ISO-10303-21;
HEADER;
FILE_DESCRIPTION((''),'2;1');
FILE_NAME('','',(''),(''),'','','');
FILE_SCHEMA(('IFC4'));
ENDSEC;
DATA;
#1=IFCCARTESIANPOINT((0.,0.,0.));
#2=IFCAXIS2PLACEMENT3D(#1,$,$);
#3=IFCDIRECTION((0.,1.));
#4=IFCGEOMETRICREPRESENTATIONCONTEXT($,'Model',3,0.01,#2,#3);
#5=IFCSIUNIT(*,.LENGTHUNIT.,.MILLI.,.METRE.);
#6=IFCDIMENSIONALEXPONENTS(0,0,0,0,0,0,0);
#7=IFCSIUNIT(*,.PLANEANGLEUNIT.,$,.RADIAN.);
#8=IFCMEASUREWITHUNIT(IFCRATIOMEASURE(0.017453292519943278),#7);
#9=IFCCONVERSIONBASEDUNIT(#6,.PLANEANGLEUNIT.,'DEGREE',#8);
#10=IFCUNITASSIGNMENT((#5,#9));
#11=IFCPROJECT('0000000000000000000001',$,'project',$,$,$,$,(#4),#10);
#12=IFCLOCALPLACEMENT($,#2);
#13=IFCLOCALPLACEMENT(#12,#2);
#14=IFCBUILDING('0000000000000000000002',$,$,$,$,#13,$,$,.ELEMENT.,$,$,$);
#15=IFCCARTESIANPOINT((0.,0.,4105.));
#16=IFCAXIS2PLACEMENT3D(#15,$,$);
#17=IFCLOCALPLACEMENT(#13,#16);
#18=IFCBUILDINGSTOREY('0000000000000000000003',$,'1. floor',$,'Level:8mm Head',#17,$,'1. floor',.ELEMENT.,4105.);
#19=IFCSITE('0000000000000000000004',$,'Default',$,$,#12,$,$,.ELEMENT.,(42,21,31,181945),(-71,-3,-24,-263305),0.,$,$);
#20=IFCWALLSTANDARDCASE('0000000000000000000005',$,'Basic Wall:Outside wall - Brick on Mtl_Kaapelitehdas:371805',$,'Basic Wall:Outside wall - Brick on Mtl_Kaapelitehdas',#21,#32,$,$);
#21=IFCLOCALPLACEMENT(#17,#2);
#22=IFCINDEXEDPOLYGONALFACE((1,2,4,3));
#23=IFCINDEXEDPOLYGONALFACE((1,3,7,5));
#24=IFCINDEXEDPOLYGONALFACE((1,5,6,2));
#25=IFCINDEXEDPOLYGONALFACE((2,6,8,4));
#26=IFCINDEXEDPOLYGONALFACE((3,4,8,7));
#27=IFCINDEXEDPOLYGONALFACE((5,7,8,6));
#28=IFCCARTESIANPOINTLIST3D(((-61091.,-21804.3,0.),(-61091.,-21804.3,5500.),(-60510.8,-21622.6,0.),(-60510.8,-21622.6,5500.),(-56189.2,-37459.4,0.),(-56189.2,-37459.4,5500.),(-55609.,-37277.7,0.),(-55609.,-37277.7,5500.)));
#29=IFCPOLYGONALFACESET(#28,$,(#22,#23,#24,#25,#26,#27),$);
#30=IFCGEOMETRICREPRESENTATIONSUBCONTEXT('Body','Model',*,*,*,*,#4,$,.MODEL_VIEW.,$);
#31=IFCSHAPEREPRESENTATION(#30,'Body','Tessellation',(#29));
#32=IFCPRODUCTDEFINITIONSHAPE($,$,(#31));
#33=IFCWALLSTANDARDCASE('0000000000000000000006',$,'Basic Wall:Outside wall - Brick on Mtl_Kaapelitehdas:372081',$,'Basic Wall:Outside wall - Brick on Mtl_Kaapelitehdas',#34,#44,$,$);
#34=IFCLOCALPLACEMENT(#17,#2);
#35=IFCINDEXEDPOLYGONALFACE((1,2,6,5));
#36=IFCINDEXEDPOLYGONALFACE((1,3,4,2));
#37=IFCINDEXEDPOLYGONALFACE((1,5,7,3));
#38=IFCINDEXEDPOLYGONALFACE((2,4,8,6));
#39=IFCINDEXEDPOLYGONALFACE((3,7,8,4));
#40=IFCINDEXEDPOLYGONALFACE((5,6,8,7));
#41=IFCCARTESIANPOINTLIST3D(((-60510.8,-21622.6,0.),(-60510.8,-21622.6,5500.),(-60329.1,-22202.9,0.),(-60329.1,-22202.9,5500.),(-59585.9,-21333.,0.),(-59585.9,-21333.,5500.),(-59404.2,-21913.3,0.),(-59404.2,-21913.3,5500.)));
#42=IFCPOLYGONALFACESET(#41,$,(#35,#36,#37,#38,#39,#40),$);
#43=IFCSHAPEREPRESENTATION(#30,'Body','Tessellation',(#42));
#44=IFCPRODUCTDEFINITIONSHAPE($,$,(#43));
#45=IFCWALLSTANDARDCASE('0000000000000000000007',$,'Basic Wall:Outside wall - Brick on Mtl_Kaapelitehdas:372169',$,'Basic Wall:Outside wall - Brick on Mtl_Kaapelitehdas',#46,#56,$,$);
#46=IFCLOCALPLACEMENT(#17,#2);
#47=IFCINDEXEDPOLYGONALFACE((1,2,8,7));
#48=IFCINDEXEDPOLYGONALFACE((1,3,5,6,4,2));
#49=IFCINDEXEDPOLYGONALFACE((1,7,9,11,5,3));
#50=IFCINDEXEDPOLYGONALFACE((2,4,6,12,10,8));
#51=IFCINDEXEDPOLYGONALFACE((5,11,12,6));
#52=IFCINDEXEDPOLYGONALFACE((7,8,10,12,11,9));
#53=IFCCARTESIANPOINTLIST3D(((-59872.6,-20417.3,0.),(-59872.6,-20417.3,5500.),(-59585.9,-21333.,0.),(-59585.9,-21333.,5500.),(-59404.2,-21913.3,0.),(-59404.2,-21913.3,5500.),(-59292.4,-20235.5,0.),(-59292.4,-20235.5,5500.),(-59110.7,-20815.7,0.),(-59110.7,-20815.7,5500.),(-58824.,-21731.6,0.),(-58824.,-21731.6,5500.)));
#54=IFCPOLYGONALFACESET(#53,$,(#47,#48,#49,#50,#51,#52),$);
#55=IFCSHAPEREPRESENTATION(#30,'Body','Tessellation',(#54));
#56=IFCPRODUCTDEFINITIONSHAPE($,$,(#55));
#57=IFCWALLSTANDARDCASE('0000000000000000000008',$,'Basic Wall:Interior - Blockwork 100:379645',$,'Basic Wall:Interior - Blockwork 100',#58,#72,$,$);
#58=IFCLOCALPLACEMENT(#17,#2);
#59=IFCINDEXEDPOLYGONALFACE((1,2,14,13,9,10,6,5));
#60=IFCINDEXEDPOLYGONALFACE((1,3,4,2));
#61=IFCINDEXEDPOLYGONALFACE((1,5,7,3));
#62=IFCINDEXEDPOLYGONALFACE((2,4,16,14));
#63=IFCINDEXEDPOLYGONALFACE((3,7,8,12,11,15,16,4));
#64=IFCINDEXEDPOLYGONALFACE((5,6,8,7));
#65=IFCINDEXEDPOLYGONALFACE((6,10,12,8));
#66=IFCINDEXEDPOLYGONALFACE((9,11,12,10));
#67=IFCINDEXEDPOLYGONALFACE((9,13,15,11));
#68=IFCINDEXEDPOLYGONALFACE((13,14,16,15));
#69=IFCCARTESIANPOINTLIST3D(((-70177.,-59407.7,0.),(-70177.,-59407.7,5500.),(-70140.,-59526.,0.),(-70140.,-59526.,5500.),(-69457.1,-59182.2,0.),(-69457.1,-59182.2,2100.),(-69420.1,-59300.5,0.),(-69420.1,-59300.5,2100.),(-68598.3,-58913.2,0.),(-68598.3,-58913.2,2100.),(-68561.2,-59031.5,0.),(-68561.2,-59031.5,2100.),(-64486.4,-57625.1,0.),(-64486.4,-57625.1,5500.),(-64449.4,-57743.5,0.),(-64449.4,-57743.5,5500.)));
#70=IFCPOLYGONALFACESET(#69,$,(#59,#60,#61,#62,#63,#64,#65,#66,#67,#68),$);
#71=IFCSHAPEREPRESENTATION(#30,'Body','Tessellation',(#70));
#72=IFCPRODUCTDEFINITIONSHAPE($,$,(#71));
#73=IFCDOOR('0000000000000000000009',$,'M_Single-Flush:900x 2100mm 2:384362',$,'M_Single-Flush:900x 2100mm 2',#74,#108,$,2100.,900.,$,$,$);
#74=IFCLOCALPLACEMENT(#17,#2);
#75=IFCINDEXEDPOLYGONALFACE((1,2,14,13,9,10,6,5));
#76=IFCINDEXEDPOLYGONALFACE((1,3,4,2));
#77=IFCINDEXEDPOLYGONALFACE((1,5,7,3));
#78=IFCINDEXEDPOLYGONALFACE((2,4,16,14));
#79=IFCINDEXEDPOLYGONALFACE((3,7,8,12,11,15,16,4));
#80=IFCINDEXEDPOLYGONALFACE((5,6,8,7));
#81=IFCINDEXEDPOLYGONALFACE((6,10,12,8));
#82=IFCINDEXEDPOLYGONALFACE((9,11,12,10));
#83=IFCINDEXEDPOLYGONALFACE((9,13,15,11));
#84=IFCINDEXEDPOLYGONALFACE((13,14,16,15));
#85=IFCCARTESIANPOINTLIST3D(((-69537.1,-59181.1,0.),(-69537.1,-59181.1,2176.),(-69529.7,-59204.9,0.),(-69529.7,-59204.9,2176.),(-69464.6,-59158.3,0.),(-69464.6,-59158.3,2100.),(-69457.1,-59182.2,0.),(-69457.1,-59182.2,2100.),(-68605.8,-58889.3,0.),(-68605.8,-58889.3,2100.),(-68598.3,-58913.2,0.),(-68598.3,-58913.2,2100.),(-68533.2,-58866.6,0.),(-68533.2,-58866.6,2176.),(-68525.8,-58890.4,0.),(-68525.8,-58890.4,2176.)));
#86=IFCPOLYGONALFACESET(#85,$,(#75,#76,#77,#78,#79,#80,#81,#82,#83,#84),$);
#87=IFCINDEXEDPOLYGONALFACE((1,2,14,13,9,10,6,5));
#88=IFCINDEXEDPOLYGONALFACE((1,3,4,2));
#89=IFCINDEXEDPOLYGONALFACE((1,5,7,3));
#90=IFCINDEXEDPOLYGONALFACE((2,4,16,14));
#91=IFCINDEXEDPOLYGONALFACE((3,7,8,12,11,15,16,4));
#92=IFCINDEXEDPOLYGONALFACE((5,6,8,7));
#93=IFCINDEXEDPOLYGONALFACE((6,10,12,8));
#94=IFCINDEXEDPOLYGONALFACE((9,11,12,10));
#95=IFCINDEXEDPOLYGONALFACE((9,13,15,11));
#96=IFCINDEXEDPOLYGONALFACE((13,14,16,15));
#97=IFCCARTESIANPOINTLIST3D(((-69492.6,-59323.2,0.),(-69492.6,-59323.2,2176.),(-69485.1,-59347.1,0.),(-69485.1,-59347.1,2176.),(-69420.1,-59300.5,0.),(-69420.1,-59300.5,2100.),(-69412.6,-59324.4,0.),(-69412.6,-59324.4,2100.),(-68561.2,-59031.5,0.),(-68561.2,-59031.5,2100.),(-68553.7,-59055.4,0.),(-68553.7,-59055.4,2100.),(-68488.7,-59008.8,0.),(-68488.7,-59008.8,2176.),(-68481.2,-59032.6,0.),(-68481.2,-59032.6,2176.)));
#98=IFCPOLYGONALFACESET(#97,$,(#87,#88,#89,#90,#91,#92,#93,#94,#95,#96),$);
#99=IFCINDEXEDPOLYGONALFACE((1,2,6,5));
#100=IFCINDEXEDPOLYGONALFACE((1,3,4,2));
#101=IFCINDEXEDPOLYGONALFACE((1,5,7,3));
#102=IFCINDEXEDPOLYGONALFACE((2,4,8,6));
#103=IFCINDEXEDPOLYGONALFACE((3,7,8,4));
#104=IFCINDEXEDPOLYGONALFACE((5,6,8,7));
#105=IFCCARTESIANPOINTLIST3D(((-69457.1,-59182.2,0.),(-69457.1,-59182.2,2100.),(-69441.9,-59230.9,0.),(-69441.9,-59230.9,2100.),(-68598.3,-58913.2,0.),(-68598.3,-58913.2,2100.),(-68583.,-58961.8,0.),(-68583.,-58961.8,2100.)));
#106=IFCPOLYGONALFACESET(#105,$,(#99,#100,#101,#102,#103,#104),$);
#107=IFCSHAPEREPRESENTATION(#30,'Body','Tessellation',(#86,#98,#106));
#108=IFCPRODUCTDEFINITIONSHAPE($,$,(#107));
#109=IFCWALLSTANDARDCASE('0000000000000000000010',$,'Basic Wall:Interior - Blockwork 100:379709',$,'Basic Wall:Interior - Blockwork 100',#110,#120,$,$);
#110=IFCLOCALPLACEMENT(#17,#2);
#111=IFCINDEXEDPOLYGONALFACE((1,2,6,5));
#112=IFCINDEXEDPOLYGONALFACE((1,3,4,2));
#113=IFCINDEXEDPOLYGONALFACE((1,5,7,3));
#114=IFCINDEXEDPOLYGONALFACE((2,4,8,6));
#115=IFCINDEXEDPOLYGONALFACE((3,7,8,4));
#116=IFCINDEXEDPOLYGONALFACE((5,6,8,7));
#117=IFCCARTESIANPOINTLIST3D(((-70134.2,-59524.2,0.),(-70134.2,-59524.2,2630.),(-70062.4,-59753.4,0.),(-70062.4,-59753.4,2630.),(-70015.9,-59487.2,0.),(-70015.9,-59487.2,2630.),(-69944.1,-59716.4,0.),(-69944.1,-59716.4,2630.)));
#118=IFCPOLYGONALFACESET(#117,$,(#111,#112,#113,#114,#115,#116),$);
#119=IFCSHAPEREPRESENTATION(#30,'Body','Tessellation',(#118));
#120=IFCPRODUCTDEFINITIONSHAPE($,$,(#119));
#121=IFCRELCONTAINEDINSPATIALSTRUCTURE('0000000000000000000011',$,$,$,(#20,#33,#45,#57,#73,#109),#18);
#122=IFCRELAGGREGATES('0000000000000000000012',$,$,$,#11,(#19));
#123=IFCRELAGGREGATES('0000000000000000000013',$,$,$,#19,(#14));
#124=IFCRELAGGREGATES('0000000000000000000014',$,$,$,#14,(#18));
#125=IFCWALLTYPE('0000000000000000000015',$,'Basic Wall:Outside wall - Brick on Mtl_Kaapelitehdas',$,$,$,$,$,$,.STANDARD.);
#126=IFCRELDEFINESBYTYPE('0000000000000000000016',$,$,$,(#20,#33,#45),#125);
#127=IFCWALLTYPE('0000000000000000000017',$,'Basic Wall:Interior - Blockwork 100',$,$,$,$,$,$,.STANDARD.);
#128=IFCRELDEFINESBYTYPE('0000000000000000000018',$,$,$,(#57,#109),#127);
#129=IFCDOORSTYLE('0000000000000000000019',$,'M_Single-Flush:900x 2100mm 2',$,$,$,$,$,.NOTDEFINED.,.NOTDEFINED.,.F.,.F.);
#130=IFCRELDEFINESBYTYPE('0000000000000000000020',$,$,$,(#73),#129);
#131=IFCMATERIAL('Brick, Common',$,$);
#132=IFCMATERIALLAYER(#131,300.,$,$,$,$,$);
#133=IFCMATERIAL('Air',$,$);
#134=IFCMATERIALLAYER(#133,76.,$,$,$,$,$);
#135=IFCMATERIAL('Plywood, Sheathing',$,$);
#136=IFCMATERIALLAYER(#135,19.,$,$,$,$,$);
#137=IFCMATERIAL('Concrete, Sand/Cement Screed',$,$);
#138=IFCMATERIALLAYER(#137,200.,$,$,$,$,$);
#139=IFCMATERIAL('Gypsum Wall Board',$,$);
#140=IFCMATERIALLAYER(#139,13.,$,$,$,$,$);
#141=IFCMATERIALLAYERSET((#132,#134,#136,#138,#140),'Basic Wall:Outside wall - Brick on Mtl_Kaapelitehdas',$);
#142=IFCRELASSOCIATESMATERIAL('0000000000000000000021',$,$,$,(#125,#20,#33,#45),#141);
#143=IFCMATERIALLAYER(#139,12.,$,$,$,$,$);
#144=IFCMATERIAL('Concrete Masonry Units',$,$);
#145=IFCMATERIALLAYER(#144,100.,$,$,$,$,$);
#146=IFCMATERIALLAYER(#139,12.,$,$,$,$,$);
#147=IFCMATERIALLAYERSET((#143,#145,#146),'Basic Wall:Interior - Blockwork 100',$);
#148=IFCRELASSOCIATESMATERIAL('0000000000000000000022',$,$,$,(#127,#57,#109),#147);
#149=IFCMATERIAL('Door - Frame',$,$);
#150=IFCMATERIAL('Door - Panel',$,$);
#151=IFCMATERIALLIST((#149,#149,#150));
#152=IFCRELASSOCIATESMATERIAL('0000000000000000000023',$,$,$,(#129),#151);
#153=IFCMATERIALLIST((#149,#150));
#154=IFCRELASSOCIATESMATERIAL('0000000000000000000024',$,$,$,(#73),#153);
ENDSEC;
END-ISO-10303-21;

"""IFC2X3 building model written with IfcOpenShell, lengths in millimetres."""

from ifc_helpers import new_model, entity, si_unit, converted_unit, direction, frame, frame_2d, origin, origin_2d_with_axis, place, context, subcontext, project, spatial, polyline, rectangle, outline, extrude, source, transform, mapped, material, material_list, layer, layer_set, layer_usage, type_object, type_shapes, element, fill, save


model = new_model("IFC2X3")

# Units and contexts
model_context = context("Model", 3, precision=0.01, world=origin(), true_north=direction((0.0, 1.0)))
body_context = subcontext(model_context, "Body", "Model", "MODEL_VIEW")
ifc_project = project(units=[si_unit("LENGTHUNIT", "METRE", prefix="MILLI"), converted_unit("PLANEANGLEUNIT", "DEGREE", entity("IfcRatioMeasure", 0.017453292519943278), si_unit("PLANEANGLEUNIT", "RADIAN"), dimensions=[0, 0, 0, 0, 0, 0, 0])], contexts=[model_context])

# Site, building, storey
site_placement = place(None, origin())
site = spatial("IfcSite", under=ifc_project, at=site_placement, Name="Default", CompositionType="ELEMENT", RefLatitude=(42, 21, 31, 181945), RefLongitude=(-71, -3, -24, -263305), RefElevation=0.0)
building_placement = place(site_placement, origin())
building = spatial("IfcBuilding", under=site, at=building_placement, CompositionType="ELEMENT")
storey_placement = place(building_placement, frame((0.0, 0.0, 4105.0)))
storey = spatial("IfcBuildingStorey", under=building, at=storey_placement, Name="1. floor", ObjectType="Level:8mm Head", LongName="1. floor", CompositionType="ELEMENT", Elevation=4105.0)

# Walls
ifc_material_1 = material(Name="Brick, Common")
ifc_layer_1 = layer(ifc_material_1, 300.0)
ifc_material_2 = material(Name="Air")
ifc_layer_2 = layer(ifc_material_2, 76.0)
ifc_material_3 = material(Name="Plywood, Sheathing")
ifc_layer_3 = layer(ifc_material_3, 19.0)
ifc_material_4 = material(Name="Concrete, Sand/Cement Screed")
ifc_layer_4 = layer(ifc_material_4, 200.0)
ifc_material_5 = material(Name="Gypsum Wall Board")
ifc_layer_5 = layer(ifc_material_5, 13.0)
ifc_layer_set_1 = layer_set([ifc_layer_1, ifc_layer_2, ifc_layer_3, ifc_layer_4, ifc_layer_5], Name="Basic Wall:Outside wall - Brick on Mtl_Kaapelitehdas")
ifc_layer_usage_1 = layer_usage(ifc_layer_set_1, "AXIS2", "NEGATIVE", 304.0)
wall_type_1 = type_object("IfcWallType", Name="Basic Wall:Outside wall - Brick on Mtl_Kaapelitehdas", PredefinedType="STANDARD", material=ifc_layer_set_1)
wall_1_placement = place(storey_placement, frame((-60800.9, -21713.5, 0.0), z_axis=(0.0, 0.0, 1.0), x_axis=(0.298805, -0.954314, 0.0)))
element("IfcWallStandardCase", 1, at=wall_1_placement, inside=storey, type_object=wall_type_1, material=ifc_layer_usage_1, Name="Basic Wall:Outside wall - Brick on Mtl_Kaapelitehdas:371805", ObjectType="Basic Wall:Outside wall - Brick on Mtl_Kaapelitehdas", context=body_context, shape_type="SweptSolid", body=[
    extrude(rectangle(XDim=16404.5, YDim=608.0, at=frame_2d((8202.3, 0.0), x_axis=(-1.0, 0.0))), origin(), (0.0, 0.0, 1.0), 5500.0),
])
ifc_layer_usage_2 = layer_usage(ifc_layer_set_1, "AXIS2", "NEGATIVE", 304.0)
wall_2_placement = place(storey_placement, frame((-60419.9, -21912.8, 0.0), z_axis=(0.0, 0.0, 1.0), x_axis=(0.954314, 0.298805, 0.0)))
element("IfcWallStandardCase", 2, at=wall_2_placement, inside=storey, type_object=wall_type_1, material=ifc_layer_usage_2, Name="Basic Wall:Outside wall - Brick on Mtl_Kaapelitehdas:372081", ObjectType="Basic Wall:Outside wall - Brick on Mtl_Kaapelitehdas", context=body_context, shape_type="SweptSolid", body=[
    extrude(rectangle(XDim=969.2, YDim=608.0, at=frame_2d((484.6, 0.0), x_axis=(-1.0, 0.0))), origin(), (0.0, 0.0, 1.0), 5500.0),
])
ifc_layer_usage_3 = layer_usage(ifc_layer_set_1, "AXIS2", "NEGATIVE", 304.0)
wall_3_placement = place(storey_placement, frame((-59114.1, -21822.4, 0.0), z_axis=(0.0, 0.0, 1.0), x_axis=(-0.298805, 0.954314, 0.0)))
element("IfcWallStandardCase", 3, at=wall_3_placement, inside=storey, type_object=wall_type_1, material=ifc_layer_usage_3, Name="Basic Wall:Outside wall - Brick on Mtl_Kaapelitehdas:372169", ObjectType="Basic Wall:Outside wall - Brick on Mtl_Kaapelitehdas", context=body_context, shape_type="SweptSolid", body=[
    extrude(outline(polyline([(1567.7, -304.0), (1567.6, 304.0), (608.0, 304.0), (0.0, 304.0), (0.0, -304.0), (959.7, -304.0), (1567.7, -304.0)])), origin(), (0.0, 0.0, 1.0), 5500.0),
])

# Wall, opening, door
ifc_layer_6 = layer(ifc_material_5, 12.0)
ifc_material_6 = material(Name="Concrete Masonry Units")
ifc_layer_7 = layer(ifc_material_6, 100.0)
ifc_layer_8 = layer(ifc_material_5, 12.0)
ifc_layer_set_2 = layer_set([ifc_layer_6, ifc_layer_7, ifc_layer_8], Name="Basic Wall:Interior - Blockwork 100")
ifc_layer_usage_4 = layer_usage(ifc_layer_set_2, "AXIS2", "NEGATIVE", 62.0)
wall_type_2 = type_object("IfcWallType", Name="Basic Wall:Interior - Blockwork 100", PredefinedType="STANDARD", material=ifc_layer_set_2)
wall_4_placement = place(storey_placement, frame((-64467.9, -57684.3, 0.0), z_axis=(0.0, 0.0, 1.0), x_axis=(-0.954277, -0.298924, 0.0)))
wall_4 = element("IfcWallStandardCase", 4, at=wall_4_placement, inside=storey, type_object=wall_type_2, material=ifc_layer_usage_4, Name="Basic Wall:Interior - Blockwork 100:379645", ObjectType="Basic Wall:Interior - Blockwork 100", context=body_context, shape_type="SweptSolid", body=[
    extrude(rectangle(XDim=5963.2, YDim=124.0, at=frame_2d((2981.6, 0.0), x_axis=(-1.0, 0.0))), origin(), (0.0, 0.0, 1.0), 5500.0),
])
opening_1_placement = place(wall_4_placement, frame((5208.9, 62.0, 0.0)))
opening_1 = element("IfcOpeningElement", 5, at=opening_1_placement, cuts=wall_4, ObjectType="Opening", context=body_context, shape_type="SweptSolid", body=[
    extrude(rectangle(XDim=900.0, YDim=2100.0, at=frame_2d((1050.0, 450.0), x_axis=(0.0, 1.0))), frame((0.0, 0.0, 0.0), z_axis=(0.0, -1.0, 0.0), x_axis=(0.0, 0.0, 1.0)), (0.0, 0.0, 1.0), 124.0),
])
ifc_material_7 = material(Name="Door - Frame")
ifc_material_8 = material(Name="Door - Panel")
ifc_material_list_1 = material_list([ifc_material_7, ifc_material_8])
ifc_material_list_2 = material_list([ifc_material_7, ifc_material_7, ifc_material_8])
door_style_1 = type_object("IfcDoorStyle", Name="M_Single-Flush:900x 2100mm 2", ConstructionType="NOTDEFINED", OperationType="NOTDEFINED", ParameterTakesPrecedence=False, Sizeable=False, material=ifc_material_list_2)
shared_shape_1 = source(origin(), body_context, "Body", "SweptSolid", [
    extrude(outline(polyline([(-526.0, -1107.0), (526.0, -1107.0), (526.0, 1069.0), (450.0, 1069.0), (450.0, -1031.0), (-450.0, -1031.0), (-450.0, 1069.0), (-526.0, 1069.0), (-526.0, -1107.0)])), frame((450.0, 124.0, 1069.0), z_axis=(0.0, 1.0, 0.0), x_axis=(1.0, 0.0, 0.0)), (0.0, 0.0, 1.0), 25.0),
    extrude(outline(polyline([(-1107.0, -526.0), (1069.0, -526.0), (1069.0, -450.0), (-1031.0, -450.0), (-1031.0, 450.0), (1069.0, 450.0), (1069.0, 526.0), (-1107.0, 526.0), (-1107.0, -526.0)])), frame((450.0, -25.0, 1069.0), z_axis=(0.0, 1.0, 0.0), x_axis=(0.0, 0.0, -1.0)), (0.0, 0.0, 1.0), 25.0),
    extrude(rectangle(XDim=51.0, YDim=900.0, at=origin_2d_with_axis()), frame((450.0, 98.5, 0.0), z_axis=(0.0, 0.0, 1.0), x_axis=(0.0, 1.0, 0.0)), (0.0, 0.0, 1.0), 2100.0),
])
type_shapes(door_style_1, [shared_shape_1])
door_1_placement = place(opening_1_placement, frame((0.0, 0.0, 0.0), z_axis=(0.0, 0.0, 1.0), x_axis=(-1.0, 0.0, 0.0)))
door_1 = element("IfcDoor", 6, at=door_1_placement, inside=storey, type_object=door_style_1, material=ifc_material_list_1, Name="M_Single-Flush:900x 2100mm 2:384362", ObjectType="M_Single-Flush:900x 2100mm 2", OverallHeight=2100.0, OverallWidth=900.0, context=body_context, shape_type="MappedRepresentation", body=[
    mapped(shared_shape_1, transform((0.0, 0.0, 0.0), scale=1.0)),
])
fill(opening_1, door_1)

# Wall
ifc_layer_usage_5 = layer_usage(ifc_layer_set_2, "AXIS2", "NEGATIVE", 62.0)
wall_5_placement = place(storey_placement, frame((-70075.1, -59505.7, 0.0), z_axis=(0.0, 0.0, 1.0), x_axis=(0.298924, -0.954277, 0.0)))
element("IfcWallStandardCase", 7, at=wall_5_placement, inside=storey, type_object=wall_type_2, material=ifc_layer_usage_5, Name="Basic Wall:Interior - Blockwork 100:379709", ObjectType="Basic Wall:Interior - Blockwork 100", context=body_context, shape_type="SweptSolid", body=[
    extrude(rectangle(XDim=240.2, YDim=124.0, at=frame_2d((120.1, 0.0), x_axis=(-1.0, 0.0))), origin(), (0.0, 0.0, 1.0), 2630.0),
])

save(model, "model.ifc")
